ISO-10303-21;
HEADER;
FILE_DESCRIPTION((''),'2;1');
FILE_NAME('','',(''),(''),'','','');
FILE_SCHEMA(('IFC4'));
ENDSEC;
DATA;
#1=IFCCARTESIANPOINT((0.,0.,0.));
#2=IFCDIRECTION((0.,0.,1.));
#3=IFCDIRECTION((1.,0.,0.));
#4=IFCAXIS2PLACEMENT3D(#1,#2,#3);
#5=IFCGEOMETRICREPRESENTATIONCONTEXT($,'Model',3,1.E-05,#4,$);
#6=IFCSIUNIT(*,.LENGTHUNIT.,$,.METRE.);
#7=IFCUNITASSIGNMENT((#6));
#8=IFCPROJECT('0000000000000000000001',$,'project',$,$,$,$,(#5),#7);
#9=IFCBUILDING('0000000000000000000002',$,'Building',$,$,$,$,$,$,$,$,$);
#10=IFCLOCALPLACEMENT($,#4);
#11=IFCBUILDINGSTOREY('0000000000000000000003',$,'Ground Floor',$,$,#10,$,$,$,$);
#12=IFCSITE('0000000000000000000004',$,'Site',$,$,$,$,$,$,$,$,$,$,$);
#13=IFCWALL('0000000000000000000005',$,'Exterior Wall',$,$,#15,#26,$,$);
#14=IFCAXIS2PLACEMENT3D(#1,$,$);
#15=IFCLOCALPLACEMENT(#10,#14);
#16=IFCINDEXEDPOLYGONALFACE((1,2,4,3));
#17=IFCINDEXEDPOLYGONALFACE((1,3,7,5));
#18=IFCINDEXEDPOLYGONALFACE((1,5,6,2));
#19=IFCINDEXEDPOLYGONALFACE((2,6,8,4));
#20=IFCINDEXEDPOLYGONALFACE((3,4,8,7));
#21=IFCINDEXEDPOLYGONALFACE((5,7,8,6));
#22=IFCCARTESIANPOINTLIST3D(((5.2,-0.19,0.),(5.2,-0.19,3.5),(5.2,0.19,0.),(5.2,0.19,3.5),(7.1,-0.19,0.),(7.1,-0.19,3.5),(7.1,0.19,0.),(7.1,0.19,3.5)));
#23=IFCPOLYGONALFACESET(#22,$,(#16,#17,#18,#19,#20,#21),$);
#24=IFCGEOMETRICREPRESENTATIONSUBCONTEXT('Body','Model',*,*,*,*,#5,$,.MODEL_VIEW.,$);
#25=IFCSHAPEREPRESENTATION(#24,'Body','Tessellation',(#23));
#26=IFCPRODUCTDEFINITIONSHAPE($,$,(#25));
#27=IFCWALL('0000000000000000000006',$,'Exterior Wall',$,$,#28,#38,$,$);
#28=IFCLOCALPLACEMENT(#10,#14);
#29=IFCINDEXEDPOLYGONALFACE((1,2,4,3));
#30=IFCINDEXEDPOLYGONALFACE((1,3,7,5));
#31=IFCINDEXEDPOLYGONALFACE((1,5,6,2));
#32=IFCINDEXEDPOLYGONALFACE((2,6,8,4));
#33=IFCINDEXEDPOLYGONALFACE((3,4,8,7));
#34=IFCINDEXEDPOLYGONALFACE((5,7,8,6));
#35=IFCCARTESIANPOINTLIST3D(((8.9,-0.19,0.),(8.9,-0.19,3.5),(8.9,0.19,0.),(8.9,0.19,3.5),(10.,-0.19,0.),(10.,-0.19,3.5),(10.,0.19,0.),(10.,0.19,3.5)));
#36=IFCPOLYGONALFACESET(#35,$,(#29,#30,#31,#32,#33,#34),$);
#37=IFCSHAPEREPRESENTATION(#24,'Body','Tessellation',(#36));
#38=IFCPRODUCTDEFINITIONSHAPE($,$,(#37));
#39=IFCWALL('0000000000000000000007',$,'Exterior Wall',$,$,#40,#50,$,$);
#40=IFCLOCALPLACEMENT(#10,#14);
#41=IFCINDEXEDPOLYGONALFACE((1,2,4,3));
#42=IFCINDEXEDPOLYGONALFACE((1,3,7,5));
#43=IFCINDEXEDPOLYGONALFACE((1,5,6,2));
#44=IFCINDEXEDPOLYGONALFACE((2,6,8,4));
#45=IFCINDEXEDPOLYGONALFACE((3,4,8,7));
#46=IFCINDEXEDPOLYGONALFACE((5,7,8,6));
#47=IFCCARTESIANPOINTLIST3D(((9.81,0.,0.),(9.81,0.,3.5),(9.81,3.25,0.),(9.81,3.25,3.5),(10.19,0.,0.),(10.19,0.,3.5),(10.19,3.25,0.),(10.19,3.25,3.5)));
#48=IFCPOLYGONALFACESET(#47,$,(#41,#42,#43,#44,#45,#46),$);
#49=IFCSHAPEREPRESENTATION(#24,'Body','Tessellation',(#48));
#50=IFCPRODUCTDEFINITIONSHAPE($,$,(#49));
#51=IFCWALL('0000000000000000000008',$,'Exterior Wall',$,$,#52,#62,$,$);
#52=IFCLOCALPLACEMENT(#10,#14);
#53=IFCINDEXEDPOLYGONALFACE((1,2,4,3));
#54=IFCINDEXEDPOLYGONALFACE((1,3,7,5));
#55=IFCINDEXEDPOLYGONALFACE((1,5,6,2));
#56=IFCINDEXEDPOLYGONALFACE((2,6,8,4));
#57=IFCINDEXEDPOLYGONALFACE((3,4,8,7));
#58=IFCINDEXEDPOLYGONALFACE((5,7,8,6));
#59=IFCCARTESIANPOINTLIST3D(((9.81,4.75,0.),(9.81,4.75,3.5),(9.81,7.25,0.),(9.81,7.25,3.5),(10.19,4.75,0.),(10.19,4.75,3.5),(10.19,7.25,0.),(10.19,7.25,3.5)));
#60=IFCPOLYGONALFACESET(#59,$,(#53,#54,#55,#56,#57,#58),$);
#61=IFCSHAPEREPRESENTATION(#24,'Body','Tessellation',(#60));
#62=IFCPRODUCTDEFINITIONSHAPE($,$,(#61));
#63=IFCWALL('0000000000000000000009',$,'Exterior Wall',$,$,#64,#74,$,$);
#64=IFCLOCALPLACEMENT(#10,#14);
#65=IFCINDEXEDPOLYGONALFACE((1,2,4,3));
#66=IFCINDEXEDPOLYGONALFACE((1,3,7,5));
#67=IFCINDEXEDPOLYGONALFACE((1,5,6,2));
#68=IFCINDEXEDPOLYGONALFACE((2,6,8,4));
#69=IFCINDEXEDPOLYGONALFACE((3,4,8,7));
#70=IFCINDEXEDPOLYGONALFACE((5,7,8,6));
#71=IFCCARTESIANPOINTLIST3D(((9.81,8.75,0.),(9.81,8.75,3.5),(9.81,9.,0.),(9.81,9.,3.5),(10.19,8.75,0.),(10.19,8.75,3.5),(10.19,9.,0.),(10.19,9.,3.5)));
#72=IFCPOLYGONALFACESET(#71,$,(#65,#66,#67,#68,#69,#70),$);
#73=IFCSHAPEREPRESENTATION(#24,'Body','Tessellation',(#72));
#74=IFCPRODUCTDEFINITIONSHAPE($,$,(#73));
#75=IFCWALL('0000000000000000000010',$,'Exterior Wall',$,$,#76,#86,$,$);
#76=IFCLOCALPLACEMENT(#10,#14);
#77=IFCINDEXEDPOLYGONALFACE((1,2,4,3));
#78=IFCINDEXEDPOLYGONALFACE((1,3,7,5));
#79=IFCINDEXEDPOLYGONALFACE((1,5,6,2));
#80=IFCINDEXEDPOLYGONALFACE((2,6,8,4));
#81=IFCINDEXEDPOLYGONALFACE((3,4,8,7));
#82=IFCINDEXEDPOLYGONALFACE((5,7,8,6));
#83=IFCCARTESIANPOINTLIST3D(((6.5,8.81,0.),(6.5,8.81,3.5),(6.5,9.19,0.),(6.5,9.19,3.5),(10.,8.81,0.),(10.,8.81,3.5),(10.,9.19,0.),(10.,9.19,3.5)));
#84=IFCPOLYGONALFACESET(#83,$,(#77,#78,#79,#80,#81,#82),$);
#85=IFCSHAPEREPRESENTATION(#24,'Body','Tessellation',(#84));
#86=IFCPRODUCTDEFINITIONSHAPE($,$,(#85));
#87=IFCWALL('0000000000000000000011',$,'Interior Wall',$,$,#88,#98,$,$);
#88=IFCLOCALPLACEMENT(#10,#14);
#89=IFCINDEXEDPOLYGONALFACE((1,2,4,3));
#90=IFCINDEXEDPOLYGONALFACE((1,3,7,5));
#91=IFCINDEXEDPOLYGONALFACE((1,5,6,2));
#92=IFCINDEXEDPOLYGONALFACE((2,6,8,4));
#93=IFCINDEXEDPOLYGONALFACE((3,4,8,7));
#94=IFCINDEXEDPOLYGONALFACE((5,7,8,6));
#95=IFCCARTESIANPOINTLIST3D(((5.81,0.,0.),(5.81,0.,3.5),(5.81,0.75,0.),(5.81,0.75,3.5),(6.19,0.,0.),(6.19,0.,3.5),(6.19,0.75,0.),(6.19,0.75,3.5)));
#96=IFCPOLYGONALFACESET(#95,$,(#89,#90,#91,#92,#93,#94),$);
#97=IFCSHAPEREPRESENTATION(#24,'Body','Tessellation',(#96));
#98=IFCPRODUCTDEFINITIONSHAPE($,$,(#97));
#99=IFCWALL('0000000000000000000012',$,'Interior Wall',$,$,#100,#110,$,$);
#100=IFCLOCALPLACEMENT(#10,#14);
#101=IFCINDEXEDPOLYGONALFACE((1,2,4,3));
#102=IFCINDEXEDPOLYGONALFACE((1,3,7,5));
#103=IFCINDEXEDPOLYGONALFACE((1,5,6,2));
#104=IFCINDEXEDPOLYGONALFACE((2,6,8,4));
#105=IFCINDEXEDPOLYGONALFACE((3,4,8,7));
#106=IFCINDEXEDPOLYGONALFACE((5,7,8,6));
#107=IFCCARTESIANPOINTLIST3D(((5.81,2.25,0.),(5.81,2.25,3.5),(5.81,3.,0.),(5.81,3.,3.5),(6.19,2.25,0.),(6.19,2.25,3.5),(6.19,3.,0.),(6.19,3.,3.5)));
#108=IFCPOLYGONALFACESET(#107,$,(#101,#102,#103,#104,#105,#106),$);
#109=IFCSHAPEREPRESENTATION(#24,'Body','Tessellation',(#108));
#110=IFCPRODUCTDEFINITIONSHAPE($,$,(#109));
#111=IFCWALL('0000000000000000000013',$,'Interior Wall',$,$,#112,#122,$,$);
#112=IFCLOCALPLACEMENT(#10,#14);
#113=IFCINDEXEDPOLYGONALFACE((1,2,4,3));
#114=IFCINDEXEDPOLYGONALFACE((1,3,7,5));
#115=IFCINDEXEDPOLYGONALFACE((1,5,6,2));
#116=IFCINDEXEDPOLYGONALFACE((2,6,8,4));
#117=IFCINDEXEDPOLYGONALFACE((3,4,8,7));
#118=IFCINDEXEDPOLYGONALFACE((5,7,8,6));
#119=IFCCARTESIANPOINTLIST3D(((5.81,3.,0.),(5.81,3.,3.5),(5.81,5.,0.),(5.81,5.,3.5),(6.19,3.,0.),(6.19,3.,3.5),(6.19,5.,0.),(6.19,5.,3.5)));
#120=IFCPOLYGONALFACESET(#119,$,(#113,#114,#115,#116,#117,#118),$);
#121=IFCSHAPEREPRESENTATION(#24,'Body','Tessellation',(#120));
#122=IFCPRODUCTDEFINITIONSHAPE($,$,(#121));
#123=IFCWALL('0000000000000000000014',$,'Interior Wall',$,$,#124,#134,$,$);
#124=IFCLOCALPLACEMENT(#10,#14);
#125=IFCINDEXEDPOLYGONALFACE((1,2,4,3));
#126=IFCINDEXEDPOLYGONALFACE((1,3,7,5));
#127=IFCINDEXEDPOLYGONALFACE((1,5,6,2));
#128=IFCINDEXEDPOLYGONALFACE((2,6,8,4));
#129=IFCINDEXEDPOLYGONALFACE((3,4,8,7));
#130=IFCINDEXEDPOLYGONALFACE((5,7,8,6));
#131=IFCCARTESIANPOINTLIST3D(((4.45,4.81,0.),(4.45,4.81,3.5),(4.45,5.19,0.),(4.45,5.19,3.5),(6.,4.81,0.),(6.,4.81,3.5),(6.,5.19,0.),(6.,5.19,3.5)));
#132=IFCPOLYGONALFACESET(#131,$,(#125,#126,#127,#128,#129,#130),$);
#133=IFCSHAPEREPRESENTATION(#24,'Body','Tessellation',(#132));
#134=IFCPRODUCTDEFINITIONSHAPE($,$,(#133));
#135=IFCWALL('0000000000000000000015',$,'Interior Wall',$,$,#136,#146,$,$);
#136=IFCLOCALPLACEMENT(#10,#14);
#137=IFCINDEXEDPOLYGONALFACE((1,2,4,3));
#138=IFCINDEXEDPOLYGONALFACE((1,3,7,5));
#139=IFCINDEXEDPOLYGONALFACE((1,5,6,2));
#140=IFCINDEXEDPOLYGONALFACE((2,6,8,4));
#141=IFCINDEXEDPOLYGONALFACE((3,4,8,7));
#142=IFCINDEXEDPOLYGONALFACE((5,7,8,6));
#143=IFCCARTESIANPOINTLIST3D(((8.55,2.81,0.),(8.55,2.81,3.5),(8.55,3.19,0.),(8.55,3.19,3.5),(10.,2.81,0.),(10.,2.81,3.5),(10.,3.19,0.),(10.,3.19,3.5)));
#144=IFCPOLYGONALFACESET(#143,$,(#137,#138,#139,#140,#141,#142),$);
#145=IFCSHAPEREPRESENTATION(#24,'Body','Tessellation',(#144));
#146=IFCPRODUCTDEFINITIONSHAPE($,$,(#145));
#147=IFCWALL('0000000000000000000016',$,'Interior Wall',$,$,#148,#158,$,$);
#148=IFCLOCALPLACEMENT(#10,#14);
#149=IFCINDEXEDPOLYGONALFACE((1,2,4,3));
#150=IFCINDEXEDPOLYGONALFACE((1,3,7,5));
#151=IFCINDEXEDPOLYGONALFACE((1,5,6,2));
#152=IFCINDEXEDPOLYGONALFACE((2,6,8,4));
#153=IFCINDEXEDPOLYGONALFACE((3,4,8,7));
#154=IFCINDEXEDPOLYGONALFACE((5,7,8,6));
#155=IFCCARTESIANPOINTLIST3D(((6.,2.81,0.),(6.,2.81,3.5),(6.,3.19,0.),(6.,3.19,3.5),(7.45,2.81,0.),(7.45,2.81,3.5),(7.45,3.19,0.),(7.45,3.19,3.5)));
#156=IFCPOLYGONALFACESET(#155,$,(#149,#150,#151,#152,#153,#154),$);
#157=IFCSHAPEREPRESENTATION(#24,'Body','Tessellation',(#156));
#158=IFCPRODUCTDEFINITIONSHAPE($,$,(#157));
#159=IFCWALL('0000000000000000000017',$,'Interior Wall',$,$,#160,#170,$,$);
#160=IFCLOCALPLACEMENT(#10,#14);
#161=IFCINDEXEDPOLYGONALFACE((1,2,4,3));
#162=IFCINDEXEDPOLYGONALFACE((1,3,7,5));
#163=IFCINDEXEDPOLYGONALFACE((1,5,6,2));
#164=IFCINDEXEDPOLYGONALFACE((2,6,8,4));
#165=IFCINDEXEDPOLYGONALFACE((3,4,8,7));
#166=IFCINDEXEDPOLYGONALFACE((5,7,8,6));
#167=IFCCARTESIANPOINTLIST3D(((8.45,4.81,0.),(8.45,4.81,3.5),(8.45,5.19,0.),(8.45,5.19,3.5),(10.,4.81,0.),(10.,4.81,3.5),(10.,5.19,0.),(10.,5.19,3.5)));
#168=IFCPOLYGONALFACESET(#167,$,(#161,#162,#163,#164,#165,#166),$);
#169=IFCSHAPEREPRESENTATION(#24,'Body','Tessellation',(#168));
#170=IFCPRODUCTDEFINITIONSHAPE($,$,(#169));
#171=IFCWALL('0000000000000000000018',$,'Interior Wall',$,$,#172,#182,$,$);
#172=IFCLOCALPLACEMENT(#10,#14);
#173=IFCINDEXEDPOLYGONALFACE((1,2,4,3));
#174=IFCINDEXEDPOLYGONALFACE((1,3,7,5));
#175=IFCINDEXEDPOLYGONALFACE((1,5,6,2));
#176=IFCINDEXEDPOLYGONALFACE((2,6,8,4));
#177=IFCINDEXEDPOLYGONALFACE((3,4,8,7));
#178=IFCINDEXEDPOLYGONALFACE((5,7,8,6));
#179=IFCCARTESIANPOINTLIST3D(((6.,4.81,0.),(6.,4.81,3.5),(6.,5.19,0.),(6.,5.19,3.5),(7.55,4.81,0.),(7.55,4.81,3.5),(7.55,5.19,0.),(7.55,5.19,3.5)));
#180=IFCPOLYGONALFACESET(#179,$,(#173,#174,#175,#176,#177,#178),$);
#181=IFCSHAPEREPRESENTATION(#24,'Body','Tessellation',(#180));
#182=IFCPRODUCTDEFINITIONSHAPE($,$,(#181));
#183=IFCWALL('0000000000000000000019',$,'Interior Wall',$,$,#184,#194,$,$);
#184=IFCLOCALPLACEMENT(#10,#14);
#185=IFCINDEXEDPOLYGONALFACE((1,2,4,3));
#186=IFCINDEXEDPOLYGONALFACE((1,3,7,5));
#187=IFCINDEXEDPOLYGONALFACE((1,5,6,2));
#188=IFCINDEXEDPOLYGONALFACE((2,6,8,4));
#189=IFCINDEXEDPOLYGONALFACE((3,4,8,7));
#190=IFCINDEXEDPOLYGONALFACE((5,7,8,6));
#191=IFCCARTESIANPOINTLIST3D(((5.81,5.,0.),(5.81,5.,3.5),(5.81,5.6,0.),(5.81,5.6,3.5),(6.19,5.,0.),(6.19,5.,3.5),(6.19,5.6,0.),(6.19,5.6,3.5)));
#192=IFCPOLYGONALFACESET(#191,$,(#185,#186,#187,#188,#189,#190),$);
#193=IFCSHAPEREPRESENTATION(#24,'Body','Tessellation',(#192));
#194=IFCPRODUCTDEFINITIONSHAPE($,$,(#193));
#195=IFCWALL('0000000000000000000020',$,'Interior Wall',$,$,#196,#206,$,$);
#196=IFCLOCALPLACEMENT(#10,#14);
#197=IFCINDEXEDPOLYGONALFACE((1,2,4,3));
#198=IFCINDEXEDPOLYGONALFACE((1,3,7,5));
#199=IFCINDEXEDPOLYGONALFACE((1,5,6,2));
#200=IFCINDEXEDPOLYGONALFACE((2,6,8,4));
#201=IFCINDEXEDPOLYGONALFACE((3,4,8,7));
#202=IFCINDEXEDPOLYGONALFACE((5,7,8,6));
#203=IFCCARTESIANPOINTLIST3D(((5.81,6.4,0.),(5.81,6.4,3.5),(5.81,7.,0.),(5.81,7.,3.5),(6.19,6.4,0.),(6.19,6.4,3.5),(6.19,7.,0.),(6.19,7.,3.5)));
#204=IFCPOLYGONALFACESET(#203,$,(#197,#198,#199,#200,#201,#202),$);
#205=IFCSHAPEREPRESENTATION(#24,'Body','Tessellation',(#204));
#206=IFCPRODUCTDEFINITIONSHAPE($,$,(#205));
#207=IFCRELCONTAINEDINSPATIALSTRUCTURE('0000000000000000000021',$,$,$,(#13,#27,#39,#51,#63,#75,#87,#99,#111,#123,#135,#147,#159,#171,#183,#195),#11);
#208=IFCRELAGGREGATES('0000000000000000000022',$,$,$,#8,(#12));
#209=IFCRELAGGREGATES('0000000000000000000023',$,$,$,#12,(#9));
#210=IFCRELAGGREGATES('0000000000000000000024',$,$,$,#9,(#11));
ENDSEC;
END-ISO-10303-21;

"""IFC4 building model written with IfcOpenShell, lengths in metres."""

from ifc_helpers import new_model, si_unit, frame, origin_with_axes, place, context, subcontext, project, spatial, indexed_curve, outline, extrude, element, save


model = new_model("IFC4")

# Units and contexts
model_context = context("Model", 3, precision=1e-05, world=origin_with_axes())
body_context = subcontext(model_context, "Body", "Model", "MODEL_VIEW")
ifc_project = project(units=[si_unit("LENGTHUNIT", "METRE")], contexts=[model_context])

# Site, building, storey
site = spatial("IfcSite", under=ifc_project, Name="Site")
building = spatial("IfcBuilding", under=site, Name="Building")
storey_placement = place(None, origin_with_axes())
storey = spatial("IfcBuildingStorey", under=building, at=storey_placement, Name="Ground Floor")

# Walls
wall_1_placement = place(storey_placement, frame((5.2, 0.0, 0.0), z_axis=(0.0, 0.0, 1.0), x_axis=(1.0, 0.0, 0.0)))
element("IfcWall", 1, at=wall_1_placement, inside=storey, Name="Exterior Wall", context=body_context, shape_type="SweptSolid", body=[
    extrude(outline(indexed_curve([(0.0, 0.0), (0.0, 0.38), (1.9, 0.38), (1.9, 0.0), (0.0, 0.0)], self_intersect=False)), frame((0.0, -0.19, 0.0), z_axis=(0.0, 0.0, 1.0), x_axis=(1.0, 0.0, 0.0)), (0.0, 0.0, 1.0), 3.5),
])
wall_2_placement = place(storey_placement, frame((8.9, 0.0, 0.0), z_axis=(0.0, 0.0, 1.0), x_axis=(1.0, 0.0, 0.0)))
element("IfcWall", 2, at=wall_2_placement, inside=storey, Name="Exterior Wall", context=body_context, shape_type="SweptSolid", body=[
    extrude(outline(indexed_curve([(0.0, 0.0), (0.0, 0.38), (1.1, 0.38), (1.1, 0.0), (0.0, 0.0)], self_intersect=False)), frame((0.0, -0.19, 0.0), z_axis=(0.0, 0.0, 1.0), x_axis=(1.0, 0.0, 0.0)), (0.0, 0.0, 1.0), 3.5),
])
wall_3_placement = place(storey_placement, frame((10.0, 0.0, 0.0), z_axis=(0.0, 0.0, 1.0), x_axis=(0.0, 1.0, 0.0)))
element("IfcWall", 3, at=wall_3_placement, inside=storey, Name="Exterior Wall", context=body_context, shape_type="SweptSolid", body=[
    extrude(outline(indexed_curve([(0.0, 0.0), (0.0, 0.38), (3.25, 0.38), (3.25, 0.0), (0.0, 0.0)], self_intersect=False)), frame((0.0, -0.19, 0.0), z_axis=(0.0, 0.0, 1.0), x_axis=(1.0, 0.0, 0.0)), (0.0, 0.0, 1.0), 3.5),
])
wall_4_placement = place(storey_placement, frame((10.0, 4.75, 0.0), z_axis=(0.0, 0.0, 1.0), x_axis=(0.0, 1.0, 0.0)))
element("IfcWall", 4, at=wall_4_placement, inside=storey, Name="Exterior Wall", context=body_context, shape_type="SweptSolid", body=[
    extrude(outline(indexed_curve([(0.0, 0.0), (0.0, 0.38), (2.5, 0.38), (2.5, 0.0), (0.0, 0.0)], self_intersect=False)), frame((0.0, -0.19, 0.0), z_axis=(0.0, 0.0, 1.0), x_axis=(1.0, 0.0, 0.0)), (0.0, 0.0, 1.0), 3.5),
])
wall_5_placement = place(storey_placement, frame((10.0, 8.75, 0.0), z_axis=(0.0, 0.0, 1.0), x_axis=(0.0, 1.0, 0.0)))
element("IfcWall", 5, at=wall_5_placement, inside=storey, Name="Exterior Wall", context=body_context, shape_type="SweptSolid", body=[
    extrude(outline(indexed_curve([(0.0, 0.0), (0.0, 0.38), (0.25, 0.38), (0.25, 0.0), (0.0, 0.0)], self_intersect=False)), frame((0.0, -0.19, 0.0), z_axis=(0.0, 0.0, 1.0), x_axis=(1.0, 0.0, 0.0)), (0.0, 0.0, 1.0), 3.5),
])
wall_6_placement = place(storey_placement, frame((10.0, 9.0, 0.0), z_axis=(0.0, 0.0, 1.0), x_axis=(-1.0, 0.0, 0.0)))
element("IfcWall", 6, at=wall_6_placement, inside=storey, Name="Exterior Wall", context=body_context, shape_type="SweptSolid", body=[
    extrude(outline(indexed_curve([(0.0, 0.0), (0.0, 0.38), (3.5, 0.38), (3.5, 0.0), (0.0, 0.0)], self_intersect=False)), frame((0.0, -0.19, 0.0), z_axis=(0.0, 0.0, 1.0), x_axis=(1.0, 0.0, 0.0)), (0.0, 0.0, 1.0), 3.5),
])
for number, where, z_axis, x_axis, name in (
    (7, (6.0, 0.0, 0.0), (0.0, 0.0, 1.0), (0.0, 1.0, 0.0), "Interior Wall"),
    (8, (6.0, 2.25, 0.0), (0.0, 0.0, 1.0), (0.0, 1.0, 0.0), "Interior Wall"),
):
    element("IfcWall", number, at=place(storey_placement, frame(where, z_axis=z_axis, x_axis=x_axis)), inside=storey, Name=name, context=body_context, shape_type="SweptSolid", body=[
        extrude(outline(indexed_curve([(0.0, 0.0), (0.0, 0.38), (0.75, 0.38), (0.75, 0.0), (0.0, 0.0)], self_intersect=False)), frame((0.0, -0.19, 0.0), z_axis=(0.0, 0.0, 1.0), x_axis=(1.0, 0.0, 0.0)), (0.0, 0.0, 1.0), 3.5),
    ])
wall_7_placement = place(storey_placement, frame((6.0, 3.0, 0.0), z_axis=(0.0, 0.0, 1.0), x_axis=(0.0, 1.0, 0.0)))
element("IfcWall", 9, at=wall_7_placement, inside=storey, Name="Interior Wall", context=body_context, shape_type="SweptSolid", body=[
    extrude(outline(indexed_curve([(0.0, 0.0), (0.0, 0.38), (2.0, 0.38), (2.0, 0.0), (0.0, 0.0)], self_intersect=False)), frame((0.0, -0.19, 0.0), z_axis=(0.0, 0.0, 1.0), x_axis=(1.0, 0.0, 0.0)), (0.0, 0.0, 1.0), 3.5),
])
wall_8_placement = place(storey_placement, frame((6.0, 5.0, 0.0), z_axis=(0.0, 0.0, 1.0), x_axis=(-1.0, 0.0, 0.0)))
element("IfcWall", 10, at=wall_8_placement, inside=storey, Name="Interior Wall", context=body_context, shape_type="SweptSolid", body=[
    extrude(outline(indexed_curve([(0.0, 0.0), (0.0, 0.38), (1.55, 0.38), (1.55, 0.0), (0.0, 0.0)], self_intersect=False)), frame((0.0, -0.19, 0.0), z_axis=(0.0, 0.0, 1.0), x_axis=(1.0, 0.0, 0.0)), (0.0, 0.0, 1.0), 3.5),
])
wall_9_placement = place(storey_placement, frame((10.0, 3.0, 0.0), z_axis=(0.0, 0.0, 1.0), x_axis=(-1.0, 0.0, 0.0)))
element("IfcWall", 11, at=wall_9_placement, inside=storey, Name="Interior Wall", context=body_context, shape_type="SweptSolid", body=[
    extrude(outline(indexed_curve([(0.0, 0.0), (0.0, 0.38), (1.45, 0.38), (1.45, 0.0), (0.0, 0.0)], self_intersect=False)), frame((0.0, -0.19, 0.0), z_axis=(0.0, 0.0, 1.0), x_axis=(1.0, 0.0, 0.0)), (0.0, 0.0, 1.0), 3.5),
])
wall_10_placement = place(storey_placement, frame((7.45, 3.0, 0.0), z_axis=(0.0, 0.0, 1.0), x_axis=(-1.0, 0.0, 0.0)))
element("IfcWall", 12, at=wall_10_placement, inside=storey, Name="Interior Wall", context=body_context, shape_type="SweptSolid", body=[
    extrude(outline(indexed_curve([(0.0, 0.0), (0.0, 0.38), (1.45, 0.38), (1.45, 0.0), (0.0, 0.0)], self_intersect=False)), frame((0.0, -0.19, 0.0), z_axis=(0.0, 0.0, 1.0), x_axis=(1.0, 0.0, 0.0)), (0.0, 0.0, 1.0), 3.5),
])
wall_11_placement = place(storey_placement, frame((10.0, 5.0, 0.0), z_axis=(0.0, 0.0, 1.0), x_axis=(-1.0, 0.0, 0.0)))
element("IfcWall", 13, at=wall_11_placement, inside=storey, Name="Interior Wall", context=body_context, shape_type="SweptSolid", body=[
    extrude(outline(indexed_curve([(0.0, 0.0), (0.0, 0.38), (1.55, 0.38), (1.55, 0.0), (0.0, 0.0)], self_intersect=False)), frame((0.0, -0.19, 0.0), z_axis=(0.0, 0.0, 1.0), x_axis=(1.0, 0.0, 0.0)), (0.0, 0.0, 1.0), 3.5),
])
wall_12_placement = place(storey_placement, frame((7.55, 5.0, 0.0), z_axis=(0.0, 0.0, 1.0), x_axis=(-1.0, 0.0, 0.0)))
element("IfcWall", 14, at=wall_12_placement, inside=storey, Name="Interior Wall", context=body_context, shape_type="SweptSolid", body=[
    extrude(outline(indexed_curve([(0.0, 0.0), (0.0, 0.38), (1.55, 0.38), (1.55, 0.0), (0.0, 0.0)], self_intersect=False)), frame((0.0, -0.19, 0.0), z_axis=(0.0, 0.0, 1.0), x_axis=(1.0, 0.0, 0.0)), (0.0, 0.0, 1.0), 3.5),
])
for number, where, z_axis, x_axis, name in (
    (15, (6.0, 5.0, 0.0), (0.0, 0.0, 1.0), (0.0, 1.0, 0.0), "Interior Wall"),
    (16, (6.0, 6.4, 0.0), (0.0, 0.0, 1.0), (0.0, 1.0, 0.0), "Interior Wall"),
):
    element("IfcWall", number, at=place(storey_placement, frame(where, z_axis=z_axis, x_axis=x_axis)), inside=storey, Name=name, context=body_context, shape_type="SweptSolid", body=[
        extrude(outline(indexed_curve([(0.0, 0.0), (0.0, 0.38), (0.6, 0.38), (0.6, 0.0), (0.0, 0.0)], self_intersect=False)), frame((0.0, -0.19, 0.0), z_axis=(0.0, 0.0, 1.0), x_axis=(1.0, 0.0, 0.0)), (0.0, 0.0, 1.0), 3.5),
    ])

save(model, "model.ifc")
